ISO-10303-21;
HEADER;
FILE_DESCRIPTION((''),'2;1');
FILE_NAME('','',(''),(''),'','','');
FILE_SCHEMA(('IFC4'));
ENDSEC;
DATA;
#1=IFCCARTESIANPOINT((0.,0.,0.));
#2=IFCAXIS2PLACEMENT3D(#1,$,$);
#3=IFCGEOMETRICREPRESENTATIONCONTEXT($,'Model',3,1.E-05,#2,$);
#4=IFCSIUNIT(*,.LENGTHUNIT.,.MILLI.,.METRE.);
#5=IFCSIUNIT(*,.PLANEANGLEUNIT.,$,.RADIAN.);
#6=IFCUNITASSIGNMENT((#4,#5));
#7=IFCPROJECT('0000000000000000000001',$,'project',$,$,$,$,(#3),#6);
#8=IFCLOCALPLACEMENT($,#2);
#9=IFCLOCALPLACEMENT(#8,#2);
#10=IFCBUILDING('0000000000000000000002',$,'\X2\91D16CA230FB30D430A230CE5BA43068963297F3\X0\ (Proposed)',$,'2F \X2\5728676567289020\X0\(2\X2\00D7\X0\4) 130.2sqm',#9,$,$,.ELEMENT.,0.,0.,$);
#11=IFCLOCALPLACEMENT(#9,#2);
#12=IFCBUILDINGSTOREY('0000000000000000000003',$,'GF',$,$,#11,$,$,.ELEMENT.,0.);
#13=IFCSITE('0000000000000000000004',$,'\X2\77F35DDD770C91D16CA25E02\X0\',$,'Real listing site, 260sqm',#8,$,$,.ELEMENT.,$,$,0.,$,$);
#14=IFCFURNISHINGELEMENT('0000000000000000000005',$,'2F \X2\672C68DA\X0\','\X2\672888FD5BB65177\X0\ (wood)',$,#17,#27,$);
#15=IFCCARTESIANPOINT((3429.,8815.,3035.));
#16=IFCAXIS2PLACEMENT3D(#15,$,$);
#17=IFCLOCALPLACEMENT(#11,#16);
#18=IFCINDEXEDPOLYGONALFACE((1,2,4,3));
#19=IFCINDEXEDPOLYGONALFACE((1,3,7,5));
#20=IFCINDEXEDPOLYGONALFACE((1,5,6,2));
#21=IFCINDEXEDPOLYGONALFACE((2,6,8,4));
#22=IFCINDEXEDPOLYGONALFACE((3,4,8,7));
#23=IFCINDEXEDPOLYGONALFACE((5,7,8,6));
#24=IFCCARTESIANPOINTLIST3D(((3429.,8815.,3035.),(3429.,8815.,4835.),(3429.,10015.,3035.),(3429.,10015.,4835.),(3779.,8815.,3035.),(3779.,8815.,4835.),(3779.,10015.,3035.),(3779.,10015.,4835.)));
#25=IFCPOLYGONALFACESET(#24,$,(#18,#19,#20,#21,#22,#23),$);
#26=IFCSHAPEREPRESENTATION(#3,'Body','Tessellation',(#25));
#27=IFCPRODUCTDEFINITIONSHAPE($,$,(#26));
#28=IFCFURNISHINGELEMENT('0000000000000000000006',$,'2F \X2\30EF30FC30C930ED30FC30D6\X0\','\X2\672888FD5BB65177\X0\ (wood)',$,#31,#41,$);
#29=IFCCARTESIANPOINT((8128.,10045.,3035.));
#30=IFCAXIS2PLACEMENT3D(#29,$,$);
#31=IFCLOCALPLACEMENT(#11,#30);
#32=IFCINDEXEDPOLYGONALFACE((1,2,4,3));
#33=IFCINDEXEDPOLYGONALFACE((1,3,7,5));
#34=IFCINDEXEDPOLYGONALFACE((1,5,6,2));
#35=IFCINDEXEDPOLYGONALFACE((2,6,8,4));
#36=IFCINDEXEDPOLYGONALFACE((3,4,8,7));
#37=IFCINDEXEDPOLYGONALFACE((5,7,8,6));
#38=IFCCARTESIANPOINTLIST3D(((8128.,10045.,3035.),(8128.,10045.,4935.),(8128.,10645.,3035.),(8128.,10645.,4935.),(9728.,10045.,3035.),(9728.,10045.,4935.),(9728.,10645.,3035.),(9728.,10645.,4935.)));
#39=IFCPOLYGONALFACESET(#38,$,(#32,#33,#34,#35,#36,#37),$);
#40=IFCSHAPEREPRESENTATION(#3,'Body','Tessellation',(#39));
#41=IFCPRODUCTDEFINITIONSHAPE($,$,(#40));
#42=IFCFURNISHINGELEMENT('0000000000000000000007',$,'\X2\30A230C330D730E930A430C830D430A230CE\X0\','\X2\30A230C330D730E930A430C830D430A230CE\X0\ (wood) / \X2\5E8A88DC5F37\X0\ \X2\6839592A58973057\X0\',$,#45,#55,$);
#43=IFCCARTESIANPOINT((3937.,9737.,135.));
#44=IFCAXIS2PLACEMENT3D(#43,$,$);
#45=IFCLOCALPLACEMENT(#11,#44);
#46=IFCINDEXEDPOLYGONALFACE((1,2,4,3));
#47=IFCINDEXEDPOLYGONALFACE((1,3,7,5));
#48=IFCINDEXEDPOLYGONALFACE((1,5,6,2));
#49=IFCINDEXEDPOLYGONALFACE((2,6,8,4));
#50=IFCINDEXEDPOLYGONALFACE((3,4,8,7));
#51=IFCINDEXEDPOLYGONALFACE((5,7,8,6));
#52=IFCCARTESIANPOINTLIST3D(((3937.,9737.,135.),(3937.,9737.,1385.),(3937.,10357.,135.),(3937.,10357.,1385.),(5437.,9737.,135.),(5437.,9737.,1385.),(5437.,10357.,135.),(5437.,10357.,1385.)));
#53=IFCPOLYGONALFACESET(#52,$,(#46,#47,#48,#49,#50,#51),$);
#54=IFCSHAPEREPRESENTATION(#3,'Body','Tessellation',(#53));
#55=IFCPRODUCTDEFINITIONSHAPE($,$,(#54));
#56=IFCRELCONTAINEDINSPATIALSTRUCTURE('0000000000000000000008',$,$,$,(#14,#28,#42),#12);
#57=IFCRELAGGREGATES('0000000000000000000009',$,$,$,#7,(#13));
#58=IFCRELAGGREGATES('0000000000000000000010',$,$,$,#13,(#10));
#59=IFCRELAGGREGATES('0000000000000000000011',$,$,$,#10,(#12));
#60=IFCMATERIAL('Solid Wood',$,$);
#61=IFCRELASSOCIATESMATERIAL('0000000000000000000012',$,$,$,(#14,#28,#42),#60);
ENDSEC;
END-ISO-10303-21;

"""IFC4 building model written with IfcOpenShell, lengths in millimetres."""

from ifc_helpers import new_model, si_unit, frame, frame_2d, origin, place, context, project, spatial, rectangle, extrude, material, element, save


model = new_model("IFC4")

# Units and contexts
model_context = context("Model", 3, precision=1e-05, world=origin())
ifc_project = project(units=[si_unit("LENGTHUNIT", "METRE", prefix="MILLI"), si_unit("PLANEANGLEUNIT", "RADIAN")], contexts=[model_context])

# Site, building, storey
site_placement = place(None, origin())
site = spatial("IfcSite", under=ifc_project, at=site_placement, Name="石川県金沢市", ObjectType="Real listing site, 260sqm", CompositionType="ELEMENT", RefElevation=0.0)
building_placement = place(site_placement, origin())
building = spatial("IfcBuilding", under=site, at=building_placement, Name="金沢・ピアノ室と防音 (Proposed)", ObjectType="2F 在来木造(2×4) 130.2sqm", CompositionType="ELEMENT", ElevationOfRefHeight=0.0, ElevationOfTerrain=0.0)
storey_placement = place(building_placement, origin())
storey = spatial("IfcBuildingStorey", under=building, at=storey_placement, Name="GF", CompositionType="ELEMENT", Elevation=0.0)

# Shared definitions
ifc_material_1 = material(Name="Solid Wood")

# Furnishing elements
furnishing_1_placement = place(storey_placement, frame((3429.0, 8815.0, 3035.0)))
element("IfcFurnishingElement", 1, at=furnishing_1_placement, inside=storey, material=ifc_material_1, Name="2F 本棚", Description="木製家具 (wood)", context=model_context, shape_type="SweptSolid", body=[
    extrude(rectangle(XDim=350.0, YDim=1200.0, at=frame_2d((175.0, 600.0))), frame((3429.0, 8815.0, 3035.0)), (0.0, 0.0, 1.0), 1800.0),
])
furnishing_2_placement = place(storey_placement, frame((8128.0, 10045.0, 3035.0)))
element("IfcFurnishingElement", 2, at=furnishing_2_placement, inside=storey, material=ifc_material_1, Name="2F ワードローブ", Description="木製家具 (wood)", context=model_context, shape_type="SweptSolid", body=[
    extrude(rectangle(XDim=1600.0, YDim=600.0, at=frame_2d((800.0, 300.0))), frame((8128.0, 10045.0, 3035.0)), (0.0, 0.0, 1.0), 1900.0),
])
furnishing_3_placement = place(storey_placement, frame((3937.0, 9737.0, 135.0)))
element("IfcFurnishingElement", 3, at=furnishing_3_placement, inside=storey, material=ifc_material_1, Name="アップライトピアノ", Description="アップライトピアノ (wood) / 床補強 根太増し", context=model_context, shape_type="SweptSolid", body=[
    extrude(rectangle(XDim=1500.0, YDim=620.0, at=frame_2d((750.0, 310.0))), frame((3937.0, 9737.0, 135.0)), (0.0, 0.0, 1.0), 1250.0),
])

save(model, "model.ifc")
